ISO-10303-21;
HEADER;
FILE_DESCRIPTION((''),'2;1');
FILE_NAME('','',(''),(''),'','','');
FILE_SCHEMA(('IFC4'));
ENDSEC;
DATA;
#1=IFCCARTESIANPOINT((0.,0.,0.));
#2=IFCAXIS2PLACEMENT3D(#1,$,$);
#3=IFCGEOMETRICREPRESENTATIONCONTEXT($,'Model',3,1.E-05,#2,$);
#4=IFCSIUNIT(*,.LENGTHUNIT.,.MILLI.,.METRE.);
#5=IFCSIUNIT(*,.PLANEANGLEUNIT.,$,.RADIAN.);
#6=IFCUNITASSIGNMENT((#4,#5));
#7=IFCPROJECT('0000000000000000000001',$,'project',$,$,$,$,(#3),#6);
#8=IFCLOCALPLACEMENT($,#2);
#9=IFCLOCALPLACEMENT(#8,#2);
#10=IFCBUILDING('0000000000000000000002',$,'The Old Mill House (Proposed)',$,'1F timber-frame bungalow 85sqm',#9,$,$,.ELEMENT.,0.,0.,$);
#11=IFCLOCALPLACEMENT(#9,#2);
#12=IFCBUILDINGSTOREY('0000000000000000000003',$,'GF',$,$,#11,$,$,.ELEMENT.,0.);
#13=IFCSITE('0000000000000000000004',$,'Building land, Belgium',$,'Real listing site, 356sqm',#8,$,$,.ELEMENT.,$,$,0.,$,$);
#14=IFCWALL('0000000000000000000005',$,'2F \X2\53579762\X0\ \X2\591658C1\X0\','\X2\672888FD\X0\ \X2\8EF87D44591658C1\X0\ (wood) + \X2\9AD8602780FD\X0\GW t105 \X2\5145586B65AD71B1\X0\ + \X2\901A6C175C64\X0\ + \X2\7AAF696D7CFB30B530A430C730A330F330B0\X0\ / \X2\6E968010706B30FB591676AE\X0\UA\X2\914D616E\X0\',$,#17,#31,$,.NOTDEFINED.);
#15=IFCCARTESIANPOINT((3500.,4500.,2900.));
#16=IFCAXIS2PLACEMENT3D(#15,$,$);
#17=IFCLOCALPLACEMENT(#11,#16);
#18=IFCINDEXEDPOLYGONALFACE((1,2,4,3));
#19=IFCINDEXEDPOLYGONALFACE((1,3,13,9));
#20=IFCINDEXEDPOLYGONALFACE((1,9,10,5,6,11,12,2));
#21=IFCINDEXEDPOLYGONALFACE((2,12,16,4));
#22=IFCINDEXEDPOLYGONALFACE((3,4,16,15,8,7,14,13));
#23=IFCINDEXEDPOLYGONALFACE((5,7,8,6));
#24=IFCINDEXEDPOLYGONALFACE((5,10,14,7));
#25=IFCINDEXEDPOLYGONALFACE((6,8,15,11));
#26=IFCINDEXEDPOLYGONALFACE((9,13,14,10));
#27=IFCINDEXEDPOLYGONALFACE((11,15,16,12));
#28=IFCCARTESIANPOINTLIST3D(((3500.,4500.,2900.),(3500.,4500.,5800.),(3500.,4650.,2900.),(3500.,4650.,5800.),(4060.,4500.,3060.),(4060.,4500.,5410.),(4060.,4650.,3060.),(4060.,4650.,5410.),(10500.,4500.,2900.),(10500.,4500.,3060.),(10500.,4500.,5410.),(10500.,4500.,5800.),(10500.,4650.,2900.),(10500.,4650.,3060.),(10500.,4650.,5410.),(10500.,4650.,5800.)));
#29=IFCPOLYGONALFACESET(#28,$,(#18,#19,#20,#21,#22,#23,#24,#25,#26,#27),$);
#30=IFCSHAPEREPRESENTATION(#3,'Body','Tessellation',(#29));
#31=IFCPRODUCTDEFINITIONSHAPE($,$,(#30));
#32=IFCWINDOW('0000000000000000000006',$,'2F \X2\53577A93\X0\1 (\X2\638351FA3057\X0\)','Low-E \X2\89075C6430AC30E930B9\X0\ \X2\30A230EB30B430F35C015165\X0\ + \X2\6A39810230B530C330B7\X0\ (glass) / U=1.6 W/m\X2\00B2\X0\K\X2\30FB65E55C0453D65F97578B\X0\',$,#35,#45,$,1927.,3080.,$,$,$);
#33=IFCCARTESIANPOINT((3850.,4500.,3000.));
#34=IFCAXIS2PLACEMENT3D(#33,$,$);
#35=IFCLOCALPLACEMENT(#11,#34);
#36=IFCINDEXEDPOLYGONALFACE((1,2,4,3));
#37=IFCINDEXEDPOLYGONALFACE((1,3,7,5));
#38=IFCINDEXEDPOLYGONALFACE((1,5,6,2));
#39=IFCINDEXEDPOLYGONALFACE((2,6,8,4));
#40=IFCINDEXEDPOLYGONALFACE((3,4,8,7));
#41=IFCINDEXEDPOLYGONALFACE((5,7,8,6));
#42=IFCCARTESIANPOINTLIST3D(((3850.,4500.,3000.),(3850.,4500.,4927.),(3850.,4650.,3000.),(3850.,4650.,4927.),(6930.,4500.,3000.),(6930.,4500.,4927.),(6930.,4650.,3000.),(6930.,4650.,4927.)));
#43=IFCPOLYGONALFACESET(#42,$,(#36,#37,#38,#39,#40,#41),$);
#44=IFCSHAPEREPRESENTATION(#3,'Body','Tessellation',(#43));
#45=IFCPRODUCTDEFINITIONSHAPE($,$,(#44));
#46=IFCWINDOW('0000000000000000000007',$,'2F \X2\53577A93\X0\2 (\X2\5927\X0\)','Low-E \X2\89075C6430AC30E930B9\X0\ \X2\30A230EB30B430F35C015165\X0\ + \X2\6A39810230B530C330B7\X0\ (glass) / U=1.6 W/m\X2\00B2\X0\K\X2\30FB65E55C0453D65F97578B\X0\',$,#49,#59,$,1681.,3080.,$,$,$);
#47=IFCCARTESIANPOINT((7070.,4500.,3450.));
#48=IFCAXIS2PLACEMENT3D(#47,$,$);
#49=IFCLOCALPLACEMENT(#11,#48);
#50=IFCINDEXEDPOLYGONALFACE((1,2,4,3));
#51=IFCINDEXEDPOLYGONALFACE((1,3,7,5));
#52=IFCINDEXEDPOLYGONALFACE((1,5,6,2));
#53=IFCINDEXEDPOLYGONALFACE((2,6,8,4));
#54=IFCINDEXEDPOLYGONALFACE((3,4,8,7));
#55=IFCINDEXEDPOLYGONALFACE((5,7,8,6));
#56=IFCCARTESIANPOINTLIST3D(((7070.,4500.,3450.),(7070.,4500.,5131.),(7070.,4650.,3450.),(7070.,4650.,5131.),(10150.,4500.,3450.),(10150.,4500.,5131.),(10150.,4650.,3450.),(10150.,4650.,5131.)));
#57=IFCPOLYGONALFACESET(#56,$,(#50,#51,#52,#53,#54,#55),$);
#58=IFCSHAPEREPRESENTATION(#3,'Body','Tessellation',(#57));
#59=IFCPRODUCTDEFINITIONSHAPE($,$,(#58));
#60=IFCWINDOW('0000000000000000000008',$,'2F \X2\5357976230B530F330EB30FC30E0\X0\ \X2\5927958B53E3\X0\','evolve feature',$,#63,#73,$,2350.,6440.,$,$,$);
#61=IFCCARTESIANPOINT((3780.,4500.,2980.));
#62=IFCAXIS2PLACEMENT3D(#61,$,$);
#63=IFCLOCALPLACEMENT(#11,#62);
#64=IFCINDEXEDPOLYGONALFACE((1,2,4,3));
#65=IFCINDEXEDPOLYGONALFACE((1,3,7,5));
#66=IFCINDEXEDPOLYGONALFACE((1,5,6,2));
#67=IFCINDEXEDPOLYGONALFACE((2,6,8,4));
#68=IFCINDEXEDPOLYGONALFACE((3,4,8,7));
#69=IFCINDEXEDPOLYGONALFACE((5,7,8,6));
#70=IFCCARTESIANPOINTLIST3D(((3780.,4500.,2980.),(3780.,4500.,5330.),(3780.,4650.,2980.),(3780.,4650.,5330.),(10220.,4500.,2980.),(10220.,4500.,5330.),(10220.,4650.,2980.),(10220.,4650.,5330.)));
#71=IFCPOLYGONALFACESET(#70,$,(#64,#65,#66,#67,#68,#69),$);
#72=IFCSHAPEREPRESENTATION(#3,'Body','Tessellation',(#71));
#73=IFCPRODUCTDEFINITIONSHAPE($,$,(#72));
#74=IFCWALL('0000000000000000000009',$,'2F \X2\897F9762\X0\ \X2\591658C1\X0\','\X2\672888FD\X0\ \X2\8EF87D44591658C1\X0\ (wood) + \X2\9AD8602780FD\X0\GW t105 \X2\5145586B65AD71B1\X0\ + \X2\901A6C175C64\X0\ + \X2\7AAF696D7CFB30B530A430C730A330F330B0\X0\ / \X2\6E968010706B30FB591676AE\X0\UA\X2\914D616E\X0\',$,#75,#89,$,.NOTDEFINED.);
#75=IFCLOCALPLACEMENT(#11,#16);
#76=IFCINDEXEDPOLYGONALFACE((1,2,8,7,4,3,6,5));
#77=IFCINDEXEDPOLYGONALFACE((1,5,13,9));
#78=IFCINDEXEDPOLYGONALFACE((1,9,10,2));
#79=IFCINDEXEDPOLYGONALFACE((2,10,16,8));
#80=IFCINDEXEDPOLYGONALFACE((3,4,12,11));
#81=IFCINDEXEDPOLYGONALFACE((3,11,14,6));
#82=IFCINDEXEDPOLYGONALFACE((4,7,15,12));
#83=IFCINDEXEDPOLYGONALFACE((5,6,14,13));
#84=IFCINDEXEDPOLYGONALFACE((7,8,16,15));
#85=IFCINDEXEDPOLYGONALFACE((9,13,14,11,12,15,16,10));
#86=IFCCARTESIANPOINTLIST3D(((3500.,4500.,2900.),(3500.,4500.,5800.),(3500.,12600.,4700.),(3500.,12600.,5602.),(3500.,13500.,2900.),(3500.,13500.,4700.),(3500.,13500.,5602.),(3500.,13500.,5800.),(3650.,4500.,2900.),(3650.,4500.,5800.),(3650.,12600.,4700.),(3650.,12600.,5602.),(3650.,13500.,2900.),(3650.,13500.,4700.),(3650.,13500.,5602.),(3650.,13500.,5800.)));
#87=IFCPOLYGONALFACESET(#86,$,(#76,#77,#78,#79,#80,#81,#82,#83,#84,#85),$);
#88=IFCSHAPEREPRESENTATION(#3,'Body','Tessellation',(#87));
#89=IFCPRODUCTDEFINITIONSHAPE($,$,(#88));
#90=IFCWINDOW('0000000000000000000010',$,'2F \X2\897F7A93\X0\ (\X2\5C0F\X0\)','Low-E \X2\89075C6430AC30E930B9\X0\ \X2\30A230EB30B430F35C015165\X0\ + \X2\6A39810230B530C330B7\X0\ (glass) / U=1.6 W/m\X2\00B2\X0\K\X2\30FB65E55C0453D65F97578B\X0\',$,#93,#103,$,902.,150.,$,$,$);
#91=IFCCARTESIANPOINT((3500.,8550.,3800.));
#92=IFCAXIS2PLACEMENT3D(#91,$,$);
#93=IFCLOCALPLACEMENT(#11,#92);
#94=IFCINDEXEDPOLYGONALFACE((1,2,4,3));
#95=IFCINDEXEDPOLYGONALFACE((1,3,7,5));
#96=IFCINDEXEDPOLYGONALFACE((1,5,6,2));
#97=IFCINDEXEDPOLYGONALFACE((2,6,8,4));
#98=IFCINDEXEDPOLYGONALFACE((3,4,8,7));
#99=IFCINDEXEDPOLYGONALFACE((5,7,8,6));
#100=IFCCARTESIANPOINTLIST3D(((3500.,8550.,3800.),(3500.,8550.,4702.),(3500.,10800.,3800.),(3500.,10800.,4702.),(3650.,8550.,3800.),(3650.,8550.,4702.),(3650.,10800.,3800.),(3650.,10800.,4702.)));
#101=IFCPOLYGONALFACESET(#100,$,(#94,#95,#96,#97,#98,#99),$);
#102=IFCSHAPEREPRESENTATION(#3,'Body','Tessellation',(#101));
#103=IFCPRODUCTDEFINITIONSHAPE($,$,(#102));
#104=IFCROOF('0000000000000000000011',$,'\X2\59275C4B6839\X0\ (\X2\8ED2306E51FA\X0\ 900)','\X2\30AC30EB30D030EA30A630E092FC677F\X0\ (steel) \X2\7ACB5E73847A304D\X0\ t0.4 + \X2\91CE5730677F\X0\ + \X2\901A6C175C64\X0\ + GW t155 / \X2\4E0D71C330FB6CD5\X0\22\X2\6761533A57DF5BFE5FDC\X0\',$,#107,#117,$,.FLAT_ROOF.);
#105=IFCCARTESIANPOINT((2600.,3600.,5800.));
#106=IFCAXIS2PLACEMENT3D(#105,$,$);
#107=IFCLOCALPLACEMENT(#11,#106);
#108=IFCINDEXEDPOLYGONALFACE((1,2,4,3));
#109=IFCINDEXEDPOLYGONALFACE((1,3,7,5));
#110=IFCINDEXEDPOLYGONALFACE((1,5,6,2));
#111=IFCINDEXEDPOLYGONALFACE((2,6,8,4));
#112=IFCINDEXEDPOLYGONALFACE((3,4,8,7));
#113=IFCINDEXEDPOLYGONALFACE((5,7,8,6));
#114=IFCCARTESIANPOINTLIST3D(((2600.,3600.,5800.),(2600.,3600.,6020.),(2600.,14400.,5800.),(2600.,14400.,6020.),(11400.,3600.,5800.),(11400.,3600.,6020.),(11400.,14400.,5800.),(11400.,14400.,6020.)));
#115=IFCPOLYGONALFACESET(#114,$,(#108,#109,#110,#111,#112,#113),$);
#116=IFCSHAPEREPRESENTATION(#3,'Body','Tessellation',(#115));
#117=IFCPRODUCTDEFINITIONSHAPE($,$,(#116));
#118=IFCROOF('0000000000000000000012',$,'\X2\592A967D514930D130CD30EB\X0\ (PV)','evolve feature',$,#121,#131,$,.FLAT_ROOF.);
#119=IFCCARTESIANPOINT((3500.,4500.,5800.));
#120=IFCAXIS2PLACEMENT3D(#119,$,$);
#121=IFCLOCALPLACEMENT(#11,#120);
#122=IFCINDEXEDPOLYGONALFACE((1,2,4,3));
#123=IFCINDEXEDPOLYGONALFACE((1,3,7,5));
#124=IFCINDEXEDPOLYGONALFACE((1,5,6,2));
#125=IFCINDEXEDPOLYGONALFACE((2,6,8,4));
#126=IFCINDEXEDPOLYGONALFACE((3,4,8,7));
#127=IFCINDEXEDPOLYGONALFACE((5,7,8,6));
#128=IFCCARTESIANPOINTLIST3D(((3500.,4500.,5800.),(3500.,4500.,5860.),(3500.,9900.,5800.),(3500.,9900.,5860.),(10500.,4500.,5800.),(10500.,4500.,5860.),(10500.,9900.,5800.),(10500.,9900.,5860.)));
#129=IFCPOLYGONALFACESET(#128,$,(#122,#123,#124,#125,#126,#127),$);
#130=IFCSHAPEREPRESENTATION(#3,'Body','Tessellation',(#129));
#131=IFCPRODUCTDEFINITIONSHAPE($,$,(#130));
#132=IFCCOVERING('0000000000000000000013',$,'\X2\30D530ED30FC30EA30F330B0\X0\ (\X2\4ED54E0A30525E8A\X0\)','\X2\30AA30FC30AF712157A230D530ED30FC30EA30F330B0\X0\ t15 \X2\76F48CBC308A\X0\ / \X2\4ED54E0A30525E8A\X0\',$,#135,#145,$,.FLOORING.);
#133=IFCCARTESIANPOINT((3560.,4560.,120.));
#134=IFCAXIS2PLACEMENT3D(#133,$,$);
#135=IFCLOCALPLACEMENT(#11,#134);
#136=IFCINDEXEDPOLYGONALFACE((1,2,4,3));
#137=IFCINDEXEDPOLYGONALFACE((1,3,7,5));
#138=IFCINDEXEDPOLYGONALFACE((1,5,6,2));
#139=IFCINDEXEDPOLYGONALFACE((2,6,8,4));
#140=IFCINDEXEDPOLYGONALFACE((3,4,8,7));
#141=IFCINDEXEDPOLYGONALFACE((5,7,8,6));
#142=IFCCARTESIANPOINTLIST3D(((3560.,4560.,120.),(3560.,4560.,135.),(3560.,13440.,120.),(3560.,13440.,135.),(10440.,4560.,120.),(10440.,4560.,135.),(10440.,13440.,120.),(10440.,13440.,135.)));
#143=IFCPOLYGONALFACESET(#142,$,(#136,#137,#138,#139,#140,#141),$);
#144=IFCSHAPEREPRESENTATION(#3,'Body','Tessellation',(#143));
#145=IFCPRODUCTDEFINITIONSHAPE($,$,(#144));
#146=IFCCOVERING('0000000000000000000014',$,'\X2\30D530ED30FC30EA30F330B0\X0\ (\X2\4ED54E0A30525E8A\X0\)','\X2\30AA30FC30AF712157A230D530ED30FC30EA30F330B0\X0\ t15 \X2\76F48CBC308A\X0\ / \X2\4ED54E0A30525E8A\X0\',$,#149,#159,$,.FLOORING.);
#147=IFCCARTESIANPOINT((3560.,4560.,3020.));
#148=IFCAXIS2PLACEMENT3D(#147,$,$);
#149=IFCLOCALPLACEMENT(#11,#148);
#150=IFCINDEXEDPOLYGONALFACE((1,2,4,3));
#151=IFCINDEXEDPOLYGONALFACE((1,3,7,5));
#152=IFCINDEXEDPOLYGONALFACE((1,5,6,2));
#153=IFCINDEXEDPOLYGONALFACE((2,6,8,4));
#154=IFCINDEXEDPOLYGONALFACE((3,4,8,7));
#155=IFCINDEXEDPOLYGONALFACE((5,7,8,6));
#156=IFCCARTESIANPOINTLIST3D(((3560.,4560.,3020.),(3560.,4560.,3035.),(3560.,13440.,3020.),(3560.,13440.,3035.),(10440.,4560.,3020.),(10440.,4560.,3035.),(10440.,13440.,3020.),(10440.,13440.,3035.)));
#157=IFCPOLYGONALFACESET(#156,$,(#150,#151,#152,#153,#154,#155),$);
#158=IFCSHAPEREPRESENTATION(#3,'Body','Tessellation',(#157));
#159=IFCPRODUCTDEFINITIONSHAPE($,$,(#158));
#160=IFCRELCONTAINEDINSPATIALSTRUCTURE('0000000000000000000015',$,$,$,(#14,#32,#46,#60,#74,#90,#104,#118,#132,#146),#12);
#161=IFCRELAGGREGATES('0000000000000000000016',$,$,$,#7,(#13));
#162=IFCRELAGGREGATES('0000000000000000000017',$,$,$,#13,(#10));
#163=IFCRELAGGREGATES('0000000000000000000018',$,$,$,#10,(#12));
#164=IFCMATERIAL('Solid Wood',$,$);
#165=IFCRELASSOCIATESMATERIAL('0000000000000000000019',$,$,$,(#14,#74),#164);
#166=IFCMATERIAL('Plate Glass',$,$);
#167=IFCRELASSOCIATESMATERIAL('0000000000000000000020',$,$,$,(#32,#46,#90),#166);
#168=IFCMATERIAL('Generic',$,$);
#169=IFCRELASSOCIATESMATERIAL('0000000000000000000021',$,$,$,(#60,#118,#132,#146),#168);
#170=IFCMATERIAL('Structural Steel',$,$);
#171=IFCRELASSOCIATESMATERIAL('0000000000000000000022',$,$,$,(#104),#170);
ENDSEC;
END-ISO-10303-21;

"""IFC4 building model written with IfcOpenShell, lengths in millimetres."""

from ifc_helpers import new_model, si_unit, frame, frame_2d, origin, place, context, project, spatial, rectangle, extrude, material, element, fill, save


model = new_model("IFC4")

# Units and contexts
model_context = context("Model", 3, precision=1e-05, world=origin())
ifc_project = project(units=[si_unit("LENGTHUNIT", "METRE", prefix="MILLI"), si_unit("PLANEANGLEUNIT", "RADIAN")], contexts=[model_context])

# Site, building, storey
site_placement = place(None, origin())
site = spatial("IfcSite", under=ifc_project, at=site_placement, Name="Building land, Belgium", ObjectType="Real listing site, 356sqm", CompositionType="ELEMENT", RefElevation=0.0)
building_placement = place(site_placement, origin())
building = spatial("IfcBuilding", under=site, at=building_placement, Name="The Old Mill House (Proposed)", ObjectType="1F timber-frame bungalow 85sqm", CompositionType="ELEMENT", ElevationOfRefHeight=0.0, ElevationOfTerrain=0.0)
storey_placement = place(building_placement, origin())
storey = spatial("IfcBuildingStorey", under=building, at=storey_placement, Name="GF", CompositionType="ELEMENT", Elevation=0.0)

# Shared definitions
ifc_material_1 = material(Name="Solid Wood")
ifc_material_2 = material(Name="Generic")

# Shared definitions
ifc_material_3 = material(Name="Plate Glass")

# Wall, openings, windows
wall_1_placement = place(storey_placement, frame((3500.0, 4500.0, 2900.0)))
wall_1 = element("IfcWall", 1, at=wall_1_placement, inside=storey, material=ifc_material_1, Name="2F 南面 外壁", Description="木製 軸組外壁 (wood) + 高性能GW t105 充填断熱 + 通気層 + 窯業系サイディング / 準耐火・外皮UA配慮", PredefinedType="NOTDEFINED", context=model_context, shape_type="SweptSolid", body=[
    extrude(rectangle(XDim=7000.0, YDim=150.0, at=frame_2d((3500.0, 75.0))), frame((3500.0, 4500.0, 2900.0)), (0.0, 0.0, 1.0), 2900.0),
])
opening_1_placement = place(storey_placement, frame((3850.0, 4500.0, 3000.0)))
opening_1 = element("IfcOpeningElement", 2, at=opening_1_placement, cuts=wall_1, PredefinedType="NOTDEFINED", context=model_context, shape_type="SweptSolid", body=[
    extrude(rectangle(XDim=3080.0, YDim=150.0, at=frame_2d((1540.0, 75.0))), frame((3850.0, 4500.0, 3000.0)), (0.0, 0.0, 1.0), 1927.0),
])
opening_2_placement = place(storey_placement, frame((7070.0, 4500.0, 3450.0)))
opening_2 = element("IfcOpeningElement", 3, at=opening_2_placement, cuts=wall_1, PredefinedType="NOTDEFINED", context=model_context, shape_type="SweptSolid", body=[
    extrude(rectangle(XDim=3080.0, YDim=150.0, at=frame_2d((1540.0, 75.0))), frame((7070.0, 4500.0, 3450.0)), (0.0, 0.0, 1.0), 1681.0),
])
opening_3_placement = place(storey_placement, frame((3780.0, 4500.0, 2980.0)))
opening_3 = element("IfcOpeningElement", 4, at=opening_3_placement, cuts=wall_1, PredefinedType="NOTDEFINED", context=model_context, shape_type="SweptSolid", body=[
    extrude(rectangle(XDim=6440.0, YDim=150.0, at=frame_2d((3220.0, 75.0))), frame((3780.0, 4500.0, 2980.0)), (0.0, 0.0, 1.0), 2350.0),
])
window_1_placement = place(storey_placement, frame((3850.0, 4500.0, 3000.0)))
window_1 = element("IfcWindow", 5, at=window_1_placement, inside=storey, material=ifc_material_3, Name="2F 南窓1 (掃出し)", Description="Low-E 複層ガラス アルゴン封入 + 樹脂サッシ (glass) / U=1.6 W/m²K・日射取得型", OverallHeight=1927.0, OverallWidth=3080.0, context=model_context, shape_type="SweptSolid", body=[
    extrude(rectangle(XDim=3080.0, YDim=150.0, at=frame_2d((1540.0, 75.0))), frame((3850.0, 4500.0, 3000.0)), (0.0, 0.0, 1.0), 1927.0),
])
fill(opening_1, window_1)
window_2_placement = place(storey_placement, frame((7070.0, 4500.0, 3450.0)))
window_2 = element("IfcWindow", 6, at=window_2_placement, inside=storey, material=ifc_material_3, Name="2F 南窓2 (大)", Description="Low-E 複層ガラス アルゴン封入 + 樹脂サッシ (glass) / U=1.6 W/m²K・日射取得型", OverallHeight=1681.0, OverallWidth=3080.0, context=model_context, shape_type="SweptSolid", body=[
    extrude(rectangle(XDim=3080.0, YDim=150.0, at=frame_2d((1540.0, 75.0))), frame((7070.0, 4500.0, 3450.0)), (0.0, 0.0, 1.0), 1681.0),
])
fill(opening_2, window_2)
window_3_placement = place(storey_placement, frame((3780.0, 4500.0, 2980.0)))
window_3 = element("IfcWindow", 7, at=window_3_placement, inside=storey, material=ifc_material_2, Name="2F 南面サンルーム 大開口", Description="evolve feature", OverallHeight=2350.0, OverallWidth=6440.0, context=model_context, shape_type="SweptSolid", body=[
    extrude(rectangle(XDim=6440.0, YDim=150.0, at=frame_2d((3220.0, 75.0))), frame((3780.0, 4500.0, 2980.0)), (0.0, 0.0, 1.0), 2350.0),
])
fill(opening_3, window_3)

# Wall, opening, window
wall_2_placement = place(storey_placement, frame((3500.0, 4500.0, 2900.0)))
wall_2 = element("IfcWall", 8, at=wall_2_placement, inside=storey, material=ifc_material_1, Name="2F 西面 外壁", Description="木製 軸組外壁 (wood) + 高性能GW t105 充填断熱 + 通気層 + 窯業系サイディング / 準耐火・外皮UA配慮", PredefinedType="NOTDEFINED", context=model_context, shape_type="SweptSolid", body=[
    extrude(rectangle(XDim=150.0, YDim=9000.0, at=frame_2d((75.0, 4500.0))), frame((3500.0, 4500.0, 2900.0)), (0.0, 0.0, 1.0), 2900.0),
])
opening_4_placement = place(storey_placement, frame((3500.0, 8550.0, 3800.0)))
opening_4 = element("IfcOpeningElement", 9, at=opening_4_placement, cuts=wall_2, PredefinedType="NOTDEFINED", context=model_context, shape_type="SweptSolid", body=[
    extrude(rectangle(XDim=150.0, YDim=2250.0, at=frame_2d((75.0, 1125.0))), frame((3500.0, 8550.0, 3800.0)), (0.0, 0.0, 1.0), 902.0),
])
window_4_placement = place(storey_placement, frame((3500.0, 8550.0, 3800.0)))
window_4 = element("IfcWindow", 10, at=window_4_placement, inside=storey, material=ifc_material_3, Name="2F 西窓 (小)", Description="Low-E 複層ガラス アルゴン封入 + 樹脂サッシ (glass) / U=1.6 W/m²K・日射取得型", OverallHeight=902.0, OverallWidth=150.0, context=model_context, shape_type="SweptSolid", body=[
    extrude(rectangle(XDim=150.0, YDim=2250.0, at=frame_2d((75.0, 1125.0))), frame((3500.0, 8550.0, 3800.0)), (0.0, 0.0, 1.0), 902.0),
])
fill(opening_4, window_4)

# Roofs
ifc_material_4 = material(Name="Structural Steel")
roof_1_placement = place(storey_placement, frame((2600.0, 3600.0, 5800.0)))
element("IfcRoof", 11, at=roof_1_placement, inside=storey, material=ifc_material_4, Name="大屋根 (軒の出 900)", Description="ガルバリウム鋼板 (steel) 立平葺き t0.4 + 野地板 + 通気層 + GW t155 / 不燃・法22条区域対応", PredefinedType="FLAT_ROOF", context=model_context, shape_type="SweptSolid", body=[
    extrude(rectangle(XDim=8800.0, YDim=10800.0, at=frame_2d((4400.0, 5400.0))), frame((2600.0, 3600.0, 5800.0)), (0.0, 0.0, 1.0), 220.0),
])
roof_2_placement = place(storey_placement, frame((3500.0, 4500.0, 5800.0)))
element("IfcRoof", 12, at=roof_2_placement, inside=storey, material=ifc_material_2, Name="太陽光パネル (PV)", Description="evolve feature", PredefinedType="FLAT_ROOF", context=model_context, shape_type="SweptSolid", body=[
    extrude(rectangle(XDim=7000.0, YDim=5400.0, at=frame_2d((3500.0, 2700.0))), frame((3500.0, 4500.0, 5800.0)), (0.0, 0.0, 1.0), 60.0),
])

# Coverings
covering_1_placement = place(storey_placement, frame((3560.0, 4560.0, 120.0)))
element("IfcCovering", 13, at=covering_1_placement, inside=storey, material=ifc_material_2, Name="フローリング (仕上げ床)", Description="オーク無垢フローリング t15 直貼り / 仕上げ床", PredefinedType="FLOORING", context=model_context, shape_type="SweptSolid", body=[
    extrude(rectangle(XDim=6880.0, YDim=8880.0, at=frame_2d((3440.0, 4440.0))), frame((3560.0, 4560.0, 120.0)), (0.0, 0.0, 1.0), 15.0),
])
covering_2_placement = place(storey_placement, frame((3560.0, 4560.0, 3020.0)))
element("IfcCovering", 14, at=covering_2_placement, inside=storey, material=ifc_material_2, Name="フローリング (仕上げ床)", Description="オーク無垢フローリング t15 直貼り / 仕上げ床", PredefinedType="FLOORING", context=model_context, shape_type="SweptSolid", body=[
    extrude(rectangle(XDim=6880.0, YDim=8880.0, at=frame_2d((3440.0, 4440.0))), frame((3560.0, 4560.0, 3020.0)), (0.0, 0.0, 1.0), 15.0),
])

save(model, "model.ifc")
